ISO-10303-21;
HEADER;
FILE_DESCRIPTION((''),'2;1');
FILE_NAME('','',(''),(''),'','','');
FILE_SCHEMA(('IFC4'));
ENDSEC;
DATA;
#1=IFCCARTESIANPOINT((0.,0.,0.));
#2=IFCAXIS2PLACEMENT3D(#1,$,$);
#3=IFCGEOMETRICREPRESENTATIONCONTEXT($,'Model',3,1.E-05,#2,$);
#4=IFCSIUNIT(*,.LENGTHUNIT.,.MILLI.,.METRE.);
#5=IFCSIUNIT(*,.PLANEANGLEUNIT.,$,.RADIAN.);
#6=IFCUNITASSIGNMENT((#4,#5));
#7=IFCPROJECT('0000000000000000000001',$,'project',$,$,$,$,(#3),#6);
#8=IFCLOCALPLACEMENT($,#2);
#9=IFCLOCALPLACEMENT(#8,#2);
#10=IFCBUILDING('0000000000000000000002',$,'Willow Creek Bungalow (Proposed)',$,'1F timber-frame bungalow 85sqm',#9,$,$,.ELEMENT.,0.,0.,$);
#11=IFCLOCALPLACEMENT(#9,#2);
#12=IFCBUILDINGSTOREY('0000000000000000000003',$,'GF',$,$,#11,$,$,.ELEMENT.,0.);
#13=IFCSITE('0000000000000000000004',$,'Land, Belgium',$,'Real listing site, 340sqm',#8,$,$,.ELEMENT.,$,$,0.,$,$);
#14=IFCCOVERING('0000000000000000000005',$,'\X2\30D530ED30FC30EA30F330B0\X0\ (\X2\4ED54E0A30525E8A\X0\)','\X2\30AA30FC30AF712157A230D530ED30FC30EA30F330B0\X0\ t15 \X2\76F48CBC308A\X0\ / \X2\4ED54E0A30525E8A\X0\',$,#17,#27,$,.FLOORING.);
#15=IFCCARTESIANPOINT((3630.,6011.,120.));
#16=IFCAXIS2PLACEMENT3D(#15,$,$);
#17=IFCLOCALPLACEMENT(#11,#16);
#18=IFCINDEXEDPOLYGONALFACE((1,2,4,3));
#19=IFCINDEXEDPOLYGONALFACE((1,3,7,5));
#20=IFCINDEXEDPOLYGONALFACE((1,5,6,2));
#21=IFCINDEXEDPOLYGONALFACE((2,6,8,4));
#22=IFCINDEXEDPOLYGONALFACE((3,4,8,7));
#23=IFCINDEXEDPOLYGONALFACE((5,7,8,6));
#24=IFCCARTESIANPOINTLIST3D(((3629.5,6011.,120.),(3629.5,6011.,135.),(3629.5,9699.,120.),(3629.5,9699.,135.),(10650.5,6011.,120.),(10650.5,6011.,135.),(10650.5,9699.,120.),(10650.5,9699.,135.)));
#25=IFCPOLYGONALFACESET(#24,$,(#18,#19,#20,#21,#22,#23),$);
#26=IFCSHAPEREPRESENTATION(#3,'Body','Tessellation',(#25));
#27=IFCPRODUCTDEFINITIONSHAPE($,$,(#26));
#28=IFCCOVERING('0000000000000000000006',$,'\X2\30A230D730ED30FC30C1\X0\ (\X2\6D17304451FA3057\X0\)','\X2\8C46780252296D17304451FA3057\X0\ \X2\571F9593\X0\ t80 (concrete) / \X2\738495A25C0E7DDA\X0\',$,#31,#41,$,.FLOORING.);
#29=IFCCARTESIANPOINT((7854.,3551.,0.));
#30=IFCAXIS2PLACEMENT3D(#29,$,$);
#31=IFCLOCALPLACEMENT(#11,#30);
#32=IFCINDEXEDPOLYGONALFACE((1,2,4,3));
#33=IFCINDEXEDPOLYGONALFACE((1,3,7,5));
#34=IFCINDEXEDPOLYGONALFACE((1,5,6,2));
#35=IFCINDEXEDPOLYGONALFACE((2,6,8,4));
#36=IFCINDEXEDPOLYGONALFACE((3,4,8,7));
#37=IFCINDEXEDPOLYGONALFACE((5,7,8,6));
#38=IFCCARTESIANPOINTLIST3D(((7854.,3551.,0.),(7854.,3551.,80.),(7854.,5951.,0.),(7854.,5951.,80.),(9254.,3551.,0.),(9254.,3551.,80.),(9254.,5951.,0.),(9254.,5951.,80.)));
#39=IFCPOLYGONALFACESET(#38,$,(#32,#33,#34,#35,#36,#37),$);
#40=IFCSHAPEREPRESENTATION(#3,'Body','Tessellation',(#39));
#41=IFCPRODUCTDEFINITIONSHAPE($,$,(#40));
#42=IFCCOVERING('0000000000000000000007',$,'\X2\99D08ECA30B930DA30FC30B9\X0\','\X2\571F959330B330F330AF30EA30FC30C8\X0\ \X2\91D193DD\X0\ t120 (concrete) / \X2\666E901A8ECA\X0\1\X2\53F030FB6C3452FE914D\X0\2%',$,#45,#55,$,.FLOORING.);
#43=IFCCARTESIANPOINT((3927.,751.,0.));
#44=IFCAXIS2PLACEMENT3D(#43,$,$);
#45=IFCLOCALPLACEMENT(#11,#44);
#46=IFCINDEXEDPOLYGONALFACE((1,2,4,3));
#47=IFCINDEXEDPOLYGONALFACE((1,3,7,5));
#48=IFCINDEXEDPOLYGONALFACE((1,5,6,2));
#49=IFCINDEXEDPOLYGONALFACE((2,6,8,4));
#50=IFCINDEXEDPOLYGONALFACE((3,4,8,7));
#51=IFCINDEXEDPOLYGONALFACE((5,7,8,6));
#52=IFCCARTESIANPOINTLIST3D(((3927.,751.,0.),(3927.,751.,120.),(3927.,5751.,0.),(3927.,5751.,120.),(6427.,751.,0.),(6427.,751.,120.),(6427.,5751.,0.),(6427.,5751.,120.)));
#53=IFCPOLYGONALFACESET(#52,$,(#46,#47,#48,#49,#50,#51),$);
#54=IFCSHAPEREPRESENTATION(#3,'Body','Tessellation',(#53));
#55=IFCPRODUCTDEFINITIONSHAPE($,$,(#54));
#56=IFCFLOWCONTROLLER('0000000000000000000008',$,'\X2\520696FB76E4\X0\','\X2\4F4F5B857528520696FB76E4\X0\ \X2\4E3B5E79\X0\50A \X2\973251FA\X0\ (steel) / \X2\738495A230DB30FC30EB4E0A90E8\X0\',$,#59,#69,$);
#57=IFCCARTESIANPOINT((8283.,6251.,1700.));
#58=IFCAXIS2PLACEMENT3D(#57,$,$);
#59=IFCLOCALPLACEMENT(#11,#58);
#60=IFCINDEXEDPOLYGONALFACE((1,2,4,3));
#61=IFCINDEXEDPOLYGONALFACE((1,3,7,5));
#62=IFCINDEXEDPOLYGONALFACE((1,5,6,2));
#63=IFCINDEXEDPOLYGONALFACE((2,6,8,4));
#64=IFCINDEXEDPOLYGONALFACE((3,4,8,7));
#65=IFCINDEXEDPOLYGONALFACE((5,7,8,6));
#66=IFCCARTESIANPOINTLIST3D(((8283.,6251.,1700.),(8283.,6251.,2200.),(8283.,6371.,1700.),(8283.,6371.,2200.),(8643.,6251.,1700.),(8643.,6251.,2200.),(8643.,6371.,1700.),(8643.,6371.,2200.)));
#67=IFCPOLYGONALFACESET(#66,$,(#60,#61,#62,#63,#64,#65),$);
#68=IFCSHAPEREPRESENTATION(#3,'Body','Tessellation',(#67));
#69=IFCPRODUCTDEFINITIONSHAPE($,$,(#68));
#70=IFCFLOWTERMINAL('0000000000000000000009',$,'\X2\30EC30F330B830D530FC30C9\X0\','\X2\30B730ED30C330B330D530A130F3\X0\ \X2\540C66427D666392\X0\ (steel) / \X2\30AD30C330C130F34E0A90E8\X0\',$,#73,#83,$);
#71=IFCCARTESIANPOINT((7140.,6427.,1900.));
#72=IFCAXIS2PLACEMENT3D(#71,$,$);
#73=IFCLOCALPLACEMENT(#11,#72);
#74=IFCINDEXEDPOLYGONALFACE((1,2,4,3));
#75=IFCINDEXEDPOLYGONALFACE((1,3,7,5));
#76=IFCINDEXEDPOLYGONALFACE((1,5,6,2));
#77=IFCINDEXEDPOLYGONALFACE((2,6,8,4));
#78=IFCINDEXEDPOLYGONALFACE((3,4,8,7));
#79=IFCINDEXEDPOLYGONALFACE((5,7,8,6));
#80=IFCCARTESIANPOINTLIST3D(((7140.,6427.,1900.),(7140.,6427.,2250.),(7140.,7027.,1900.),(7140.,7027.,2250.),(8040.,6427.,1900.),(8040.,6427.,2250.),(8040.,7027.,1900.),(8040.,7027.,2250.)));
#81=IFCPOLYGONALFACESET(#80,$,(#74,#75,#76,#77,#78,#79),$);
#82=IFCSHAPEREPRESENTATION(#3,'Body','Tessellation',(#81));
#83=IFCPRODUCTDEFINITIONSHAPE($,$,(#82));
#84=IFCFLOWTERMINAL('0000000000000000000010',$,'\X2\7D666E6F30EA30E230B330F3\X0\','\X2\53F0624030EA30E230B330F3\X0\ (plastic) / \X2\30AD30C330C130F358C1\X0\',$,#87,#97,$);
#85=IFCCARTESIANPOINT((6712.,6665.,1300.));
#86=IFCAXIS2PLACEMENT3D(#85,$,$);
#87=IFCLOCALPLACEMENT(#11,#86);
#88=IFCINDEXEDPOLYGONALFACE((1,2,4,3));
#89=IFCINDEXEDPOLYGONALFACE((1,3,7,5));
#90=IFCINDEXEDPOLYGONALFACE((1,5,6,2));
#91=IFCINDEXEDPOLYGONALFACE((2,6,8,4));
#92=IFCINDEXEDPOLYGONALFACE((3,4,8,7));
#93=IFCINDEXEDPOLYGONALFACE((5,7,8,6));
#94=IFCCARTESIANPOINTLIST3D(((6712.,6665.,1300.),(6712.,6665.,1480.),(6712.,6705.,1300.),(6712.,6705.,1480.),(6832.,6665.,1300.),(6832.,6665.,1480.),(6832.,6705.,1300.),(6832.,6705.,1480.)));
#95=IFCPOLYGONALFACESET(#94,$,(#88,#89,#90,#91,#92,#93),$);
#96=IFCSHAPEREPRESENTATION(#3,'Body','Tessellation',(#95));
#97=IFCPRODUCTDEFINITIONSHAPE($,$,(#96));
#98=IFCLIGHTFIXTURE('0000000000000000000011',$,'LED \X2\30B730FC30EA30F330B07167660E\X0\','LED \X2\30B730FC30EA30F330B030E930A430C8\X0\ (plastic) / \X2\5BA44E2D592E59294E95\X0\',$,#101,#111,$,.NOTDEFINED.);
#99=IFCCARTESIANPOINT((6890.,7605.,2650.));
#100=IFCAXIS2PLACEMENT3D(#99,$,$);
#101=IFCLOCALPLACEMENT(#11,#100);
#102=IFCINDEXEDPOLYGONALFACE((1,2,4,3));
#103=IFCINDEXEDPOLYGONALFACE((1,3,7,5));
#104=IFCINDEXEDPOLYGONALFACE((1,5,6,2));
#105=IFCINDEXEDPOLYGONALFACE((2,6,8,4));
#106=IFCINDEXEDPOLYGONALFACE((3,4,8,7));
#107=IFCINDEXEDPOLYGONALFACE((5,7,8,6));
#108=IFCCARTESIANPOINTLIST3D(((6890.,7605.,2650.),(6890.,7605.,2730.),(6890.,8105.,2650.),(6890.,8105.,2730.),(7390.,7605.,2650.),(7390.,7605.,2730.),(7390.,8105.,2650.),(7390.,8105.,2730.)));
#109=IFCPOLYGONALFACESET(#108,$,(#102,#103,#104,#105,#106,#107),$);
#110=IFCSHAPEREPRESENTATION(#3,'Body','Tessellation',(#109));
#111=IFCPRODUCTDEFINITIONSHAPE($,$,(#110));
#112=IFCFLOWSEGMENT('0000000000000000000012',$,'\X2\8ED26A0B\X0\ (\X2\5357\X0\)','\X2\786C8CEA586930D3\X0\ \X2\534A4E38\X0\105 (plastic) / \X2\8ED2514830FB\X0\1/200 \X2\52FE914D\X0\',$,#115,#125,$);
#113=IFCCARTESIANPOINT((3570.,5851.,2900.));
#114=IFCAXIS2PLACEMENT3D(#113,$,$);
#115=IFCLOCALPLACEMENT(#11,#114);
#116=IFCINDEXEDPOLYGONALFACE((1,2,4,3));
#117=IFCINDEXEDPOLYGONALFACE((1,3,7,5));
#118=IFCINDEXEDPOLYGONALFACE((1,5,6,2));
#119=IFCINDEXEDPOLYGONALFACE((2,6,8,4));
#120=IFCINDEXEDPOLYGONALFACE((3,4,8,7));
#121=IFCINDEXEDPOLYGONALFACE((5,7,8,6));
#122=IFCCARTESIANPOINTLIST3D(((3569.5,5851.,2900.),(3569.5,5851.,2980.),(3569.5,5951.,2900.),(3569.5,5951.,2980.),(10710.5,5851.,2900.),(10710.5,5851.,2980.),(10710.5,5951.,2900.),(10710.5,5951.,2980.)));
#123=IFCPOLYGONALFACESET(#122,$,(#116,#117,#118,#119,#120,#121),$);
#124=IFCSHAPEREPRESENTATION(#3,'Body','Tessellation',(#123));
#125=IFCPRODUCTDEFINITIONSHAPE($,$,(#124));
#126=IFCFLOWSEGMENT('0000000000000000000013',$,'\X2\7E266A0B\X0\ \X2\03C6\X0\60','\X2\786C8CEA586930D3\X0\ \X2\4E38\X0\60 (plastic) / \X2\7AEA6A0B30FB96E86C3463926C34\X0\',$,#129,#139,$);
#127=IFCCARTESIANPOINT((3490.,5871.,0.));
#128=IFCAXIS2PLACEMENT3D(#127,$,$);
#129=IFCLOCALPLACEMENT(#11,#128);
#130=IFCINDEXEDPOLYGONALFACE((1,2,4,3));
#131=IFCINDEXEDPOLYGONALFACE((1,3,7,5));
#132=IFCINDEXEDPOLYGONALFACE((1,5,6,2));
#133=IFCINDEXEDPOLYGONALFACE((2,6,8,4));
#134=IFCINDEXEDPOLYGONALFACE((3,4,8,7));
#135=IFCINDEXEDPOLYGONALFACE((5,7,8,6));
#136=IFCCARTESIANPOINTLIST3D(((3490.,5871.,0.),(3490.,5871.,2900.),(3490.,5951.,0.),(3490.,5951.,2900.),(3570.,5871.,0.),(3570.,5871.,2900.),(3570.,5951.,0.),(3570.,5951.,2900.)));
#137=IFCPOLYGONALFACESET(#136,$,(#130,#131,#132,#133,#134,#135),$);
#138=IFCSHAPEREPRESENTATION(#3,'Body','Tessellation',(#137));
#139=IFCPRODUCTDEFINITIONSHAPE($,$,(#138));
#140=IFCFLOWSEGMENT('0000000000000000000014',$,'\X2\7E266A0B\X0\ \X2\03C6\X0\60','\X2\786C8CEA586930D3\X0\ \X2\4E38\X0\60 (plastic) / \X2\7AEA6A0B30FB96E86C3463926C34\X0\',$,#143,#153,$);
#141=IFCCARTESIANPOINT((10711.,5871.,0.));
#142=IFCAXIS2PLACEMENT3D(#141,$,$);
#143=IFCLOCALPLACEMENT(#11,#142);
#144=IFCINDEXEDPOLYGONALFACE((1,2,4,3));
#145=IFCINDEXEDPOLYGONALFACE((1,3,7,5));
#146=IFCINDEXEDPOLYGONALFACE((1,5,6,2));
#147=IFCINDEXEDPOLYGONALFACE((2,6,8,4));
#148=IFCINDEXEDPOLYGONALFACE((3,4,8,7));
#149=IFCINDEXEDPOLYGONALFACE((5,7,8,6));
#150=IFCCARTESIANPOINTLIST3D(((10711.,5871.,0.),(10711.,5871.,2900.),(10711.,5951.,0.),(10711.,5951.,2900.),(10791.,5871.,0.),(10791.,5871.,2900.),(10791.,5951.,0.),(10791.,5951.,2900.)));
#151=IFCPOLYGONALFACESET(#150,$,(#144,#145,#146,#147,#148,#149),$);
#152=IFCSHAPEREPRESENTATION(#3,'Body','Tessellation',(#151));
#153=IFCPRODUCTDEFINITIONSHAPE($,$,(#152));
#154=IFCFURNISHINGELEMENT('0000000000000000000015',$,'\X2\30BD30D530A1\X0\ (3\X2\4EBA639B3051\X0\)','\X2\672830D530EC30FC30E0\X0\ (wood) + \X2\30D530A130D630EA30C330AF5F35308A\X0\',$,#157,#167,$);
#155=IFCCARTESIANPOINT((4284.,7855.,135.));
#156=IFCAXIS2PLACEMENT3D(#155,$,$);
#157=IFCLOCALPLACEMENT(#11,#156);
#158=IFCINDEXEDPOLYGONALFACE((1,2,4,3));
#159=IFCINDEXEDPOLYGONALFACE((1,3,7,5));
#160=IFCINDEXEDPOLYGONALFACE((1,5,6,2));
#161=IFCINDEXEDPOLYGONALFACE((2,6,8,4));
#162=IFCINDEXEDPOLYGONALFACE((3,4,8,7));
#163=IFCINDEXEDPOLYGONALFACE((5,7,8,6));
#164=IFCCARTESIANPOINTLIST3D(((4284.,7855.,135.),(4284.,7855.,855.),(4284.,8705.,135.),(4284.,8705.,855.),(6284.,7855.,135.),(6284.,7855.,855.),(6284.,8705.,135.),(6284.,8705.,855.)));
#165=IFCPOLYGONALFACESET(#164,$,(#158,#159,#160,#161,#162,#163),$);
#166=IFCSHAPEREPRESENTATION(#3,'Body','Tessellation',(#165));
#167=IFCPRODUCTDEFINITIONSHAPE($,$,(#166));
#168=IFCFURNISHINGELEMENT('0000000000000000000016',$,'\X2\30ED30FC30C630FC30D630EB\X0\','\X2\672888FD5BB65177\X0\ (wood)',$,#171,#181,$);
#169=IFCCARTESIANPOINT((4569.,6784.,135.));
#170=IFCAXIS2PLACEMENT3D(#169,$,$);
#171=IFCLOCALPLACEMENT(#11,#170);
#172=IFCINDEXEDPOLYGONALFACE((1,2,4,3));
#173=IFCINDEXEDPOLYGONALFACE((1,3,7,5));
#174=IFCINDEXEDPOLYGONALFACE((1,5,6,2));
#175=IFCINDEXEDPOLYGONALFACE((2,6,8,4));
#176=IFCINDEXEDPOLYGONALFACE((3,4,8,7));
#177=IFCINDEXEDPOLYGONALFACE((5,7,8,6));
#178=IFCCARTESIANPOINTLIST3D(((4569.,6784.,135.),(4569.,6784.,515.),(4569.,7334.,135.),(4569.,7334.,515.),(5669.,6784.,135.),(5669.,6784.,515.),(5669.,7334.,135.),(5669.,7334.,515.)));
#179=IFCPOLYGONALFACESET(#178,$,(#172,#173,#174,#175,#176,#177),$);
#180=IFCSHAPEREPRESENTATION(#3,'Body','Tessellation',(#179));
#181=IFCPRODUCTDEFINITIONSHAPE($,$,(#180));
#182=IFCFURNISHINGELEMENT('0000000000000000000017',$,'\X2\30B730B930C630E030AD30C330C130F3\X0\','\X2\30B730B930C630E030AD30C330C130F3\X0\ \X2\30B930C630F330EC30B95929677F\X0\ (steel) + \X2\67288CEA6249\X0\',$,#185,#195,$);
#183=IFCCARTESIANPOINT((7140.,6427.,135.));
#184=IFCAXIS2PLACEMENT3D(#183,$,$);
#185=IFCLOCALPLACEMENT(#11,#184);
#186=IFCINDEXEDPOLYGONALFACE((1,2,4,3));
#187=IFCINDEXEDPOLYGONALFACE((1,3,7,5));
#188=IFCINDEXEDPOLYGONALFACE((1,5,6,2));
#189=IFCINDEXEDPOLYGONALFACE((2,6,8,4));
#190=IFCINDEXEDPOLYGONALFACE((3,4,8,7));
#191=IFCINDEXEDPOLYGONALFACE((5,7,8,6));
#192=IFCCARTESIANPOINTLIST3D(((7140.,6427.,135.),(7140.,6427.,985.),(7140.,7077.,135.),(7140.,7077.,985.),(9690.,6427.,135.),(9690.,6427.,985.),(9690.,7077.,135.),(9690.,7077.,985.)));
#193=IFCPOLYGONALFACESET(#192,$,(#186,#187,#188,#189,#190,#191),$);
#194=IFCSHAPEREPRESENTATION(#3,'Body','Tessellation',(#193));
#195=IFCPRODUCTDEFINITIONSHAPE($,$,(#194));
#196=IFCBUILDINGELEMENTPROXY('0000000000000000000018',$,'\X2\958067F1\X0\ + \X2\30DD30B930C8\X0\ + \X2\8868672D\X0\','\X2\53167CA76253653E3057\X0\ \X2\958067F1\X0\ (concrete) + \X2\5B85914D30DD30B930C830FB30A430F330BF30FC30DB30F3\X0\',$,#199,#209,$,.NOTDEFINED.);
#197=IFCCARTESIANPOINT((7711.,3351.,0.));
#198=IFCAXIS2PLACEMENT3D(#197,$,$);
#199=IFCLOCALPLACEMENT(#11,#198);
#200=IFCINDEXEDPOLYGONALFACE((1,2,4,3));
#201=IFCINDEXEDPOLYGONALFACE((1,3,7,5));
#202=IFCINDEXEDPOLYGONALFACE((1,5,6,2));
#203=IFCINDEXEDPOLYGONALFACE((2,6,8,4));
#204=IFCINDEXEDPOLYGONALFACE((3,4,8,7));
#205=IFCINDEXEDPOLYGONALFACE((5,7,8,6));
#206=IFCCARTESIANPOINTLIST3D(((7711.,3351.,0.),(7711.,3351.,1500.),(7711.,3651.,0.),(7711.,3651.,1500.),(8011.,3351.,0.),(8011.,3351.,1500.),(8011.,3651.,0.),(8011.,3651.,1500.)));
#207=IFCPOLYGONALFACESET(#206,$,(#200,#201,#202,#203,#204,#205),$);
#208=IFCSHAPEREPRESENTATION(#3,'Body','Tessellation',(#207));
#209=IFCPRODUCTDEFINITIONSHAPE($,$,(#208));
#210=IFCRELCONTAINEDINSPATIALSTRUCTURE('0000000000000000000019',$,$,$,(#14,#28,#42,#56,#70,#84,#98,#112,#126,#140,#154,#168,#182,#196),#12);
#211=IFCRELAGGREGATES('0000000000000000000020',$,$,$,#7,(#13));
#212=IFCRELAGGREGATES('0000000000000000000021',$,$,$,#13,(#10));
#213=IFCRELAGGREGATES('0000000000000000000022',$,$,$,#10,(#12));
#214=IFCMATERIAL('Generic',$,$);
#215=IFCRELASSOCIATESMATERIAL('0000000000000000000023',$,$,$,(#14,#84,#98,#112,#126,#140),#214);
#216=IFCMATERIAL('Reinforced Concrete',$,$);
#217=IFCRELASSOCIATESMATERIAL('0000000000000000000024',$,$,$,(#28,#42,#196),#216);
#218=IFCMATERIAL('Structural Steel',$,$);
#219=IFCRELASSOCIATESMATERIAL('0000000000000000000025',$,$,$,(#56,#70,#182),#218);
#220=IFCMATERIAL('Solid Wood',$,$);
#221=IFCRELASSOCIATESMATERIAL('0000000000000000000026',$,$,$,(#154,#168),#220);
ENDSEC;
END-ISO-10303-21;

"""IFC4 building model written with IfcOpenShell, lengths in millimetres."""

from ifc_helpers import new_model, si_unit, frame, frame_2d, origin, place, context, project, spatial, rectangle, extrude, material, element, save


model = new_model("IFC4")

# Units and contexts
model_context = context("Model", 3, precision=1e-05, world=origin())
ifc_project = project(units=[si_unit("LENGTHUNIT", "METRE", prefix="MILLI"), si_unit("PLANEANGLEUNIT", "RADIAN")], contexts=[model_context])

# Site, building, storey
site_placement = place(None, origin())
site = spatial("IfcSite", under=ifc_project, at=site_placement, Name="Land, Belgium", ObjectType="Real listing site, 340sqm", CompositionType="ELEMENT", RefElevation=0.0)
building_placement = place(site_placement, origin())
building = spatial("IfcBuilding", under=site, at=building_placement, Name="Willow Creek Bungalow (Proposed)", ObjectType="1F timber-frame bungalow 85sqm", CompositionType="ELEMENT", ElevationOfRefHeight=0.0, ElevationOfTerrain=0.0)
storey_placement = place(building_placement, origin())
storey = spatial("IfcBuildingStorey", under=building, at=storey_placement, Name="GF", CompositionType="ELEMENT", Elevation=0.0)

# Shared definitions
ifc_material_1 = material(Name="Solid Wood")

# Shared definitions
ifc_material_2 = material(Name="Reinforced Concrete")

# Shared definitions
ifc_material_3 = material(Name="Structural Steel")

# Coverings
ifc_material_4 = material(Name="Generic")
covering_1_placement = place(storey_placement, frame((3630.0, 6011.0, 120.0)))
element("IfcCovering", 1, at=covering_1_placement, inside=storey, material=ifc_material_4, Name="フローリング (仕上げ床)", Description="オーク無垢フローリング t15 直貼り / 仕上げ床", PredefinedType="FLOORING", context=model_context, shape_type="SweptSolid", body=[
    extrude(rectangle(XDim=7021.0, YDim=3688.0, at=frame_2d((3510.0, 1844.0))), frame((3630.0, 6011.0, 120.0)), (0.0, 0.0, 1.0), 15.0),
])
covering_2_placement = place(storey_placement, frame((7854.0, 3551.0, 0.0)))
element("IfcCovering", 2, at=covering_2_placement, inside=storey, material=ifc_material_2, Name="アプローチ (洗い出し)", Description="豆砂利洗い出し 土間 t80 (concrete) / 玄関導線", PredefinedType="FLOORING", context=model_context, shape_type="SweptSolid", body=[
    extrude(rectangle(XDim=1400.0, YDim=2400.0, at=frame_2d((700.0, 1200.0))), frame((7854.0, 3551.0, 0.0)), (0.0, 0.0, 1.0), 80.0),
])
covering_3_placement = place(storey_placement, frame((3927.0, 751.0, 0.0)))
element("IfcCovering", 3, at=covering_3_placement, inside=storey, material=ifc_material_2, Name="駐車スペース", Description="土間コンクリート 金鏝 t120 (concrete) / 普通車1台・水勾配2%", PredefinedType="FLOORING", context=model_context, shape_type="SweptSolid", body=[
    extrude(rectangle(XDim=2500.0, YDim=5000.0, at=frame_2d((1250.0, 2500.0))), frame((3927.0, 751.0, 0.0)), (0.0, 0.0, 1.0), 120.0),
])

# Flow controller
flow_controller_placement = place(storey_placement, frame((8283.0, 6251.0, 1700.0)))
element("IfcFlowController", 4, at=flow_controller_placement, inside=storey, material=ifc_material_3, Name="分電盤", Description="住宅用分電盤 主幹50A 露出 (steel) / 玄関ホール上部", context=model_context, shape_type="SweptSolid", body=[
    extrude(rectangle(XDim=360.0, YDim=120.0, at=frame_2d((180.0, 60.0))), frame((8283.0, 6251.0, 1700.0)), (0.0, 0.0, 1.0), 500.0),
])

# Flow terminals
flow_terminal_1_placement = place(storey_placement, frame((7140.0, 6427.0, 1900.0)))
element("IfcFlowTerminal", 5, at=flow_terminal_1_placement, inside=storey, material=ifc_material_3, Name="レンジフード", Description="シロッコファン 同時給排 (steel) / キッチン上部", context=model_context, shape_type="SweptSolid", body=[
    extrude(rectangle(XDim=900.0, YDim=600.0, at=frame_2d((450.0, 300.0))), frame((7140.0, 6427.0, 1900.0)), (0.0, 0.0, 1.0), 350.0),
])
flow_terminal_2_placement = place(storey_placement, frame((6712.0, 6665.0, 1300.0)))
element("IfcFlowTerminal", 6, at=flow_terminal_2_placement, inside=storey, material=ifc_material_4, Name="給湯リモコン", Description="台所リモコン (plastic) / キッチン壁", context=model_context, shape_type="SweptSolid", body=[
    extrude(rectangle(XDim=120.0, YDim=40.0, at=frame_2d((60.0, 20.0))), frame((6712.0, 6665.0, 1300.0)), (0.0, 0.0, 1.0), 180.0),
])

# Light fixture
light_fixture_placement = place(storey_placement, frame((6890.0, 7605.0, 2650.0)))
element("IfcLightFixture", 7, at=light_fixture_placement, inside=storey, material=ifc_material_4, Name="LED シーリング照明", Description="LED シーリングライト (plastic) / 室中央天井", PredefinedType="NOTDEFINED", context=model_context, shape_type="SweptSolid", body=[
    extrude(rectangle(XDim=500.0, YDim=500.0, at=frame_2d((250.0, 250.0))), frame((6890.0, 7605.0, 2650.0)), (0.0, 0.0, 1.0), 80.0),
])

# Flow segments
flow_segment_1_placement = place(storey_placement, frame((3570.0, 5851.0, 2900.0)))
element("IfcFlowSegment", 8, at=flow_segment_1_placement, inside=storey, material=ifc_material_4, Name="軒樋 (南)", Description="硬質塩ビ 半丸105 (plastic) / 軒先・1/200 勾配", context=model_context, shape_type="SweptSolid", body=[
    extrude(rectangle(XDim=7141.0, YDim=100.0, at=frame_2d((3570.0, 50.0))), frame((3570.0, 5851.0, 2900.0)), (0.0, 0.0, 1.0), 80.0),
])
flow_segment_2_placement = place(storey_placement, frame((3490.0, 5871.0, 0.0)))
element("IfcFlowSegment", 9, at=flow_segment_2_placement, inside=storey, material=ifc_material_4, Name="縦樋 φ60", Description="硬質塩ビ 丸60 (plastic) / 竪樋・雨水排水", context=model_context, shape_type="SweptSolid", body=[
    extrude(rectangle(XDim=80.0, YDim=80.0, at=frame_2d((40.0, 40.0))), frame((3490.0, 5871.0, 0.0)), (0.0, 0.0, 1.0), 2900.0),
])
flow_segment_3_placement = place(storey_placement, frame((10711.0, 5871.0, 0.0)))
element("IfcFlowSegment", 10, at=flow_segment_3_placement, inside=storey, material=ifc_material_4, Name="縦樋 φ60", Description="硬質塩ビ 丸60 (plastic) / 竪樋・雨水排水", context=model_context, shape_type="SweptSolid", body=[
    extrude(rectangle(XDim=80.0, YDim=80.0, at=frame_2d((40.0, 40.0))), frame((10711.0, 5871.0, 0.0)), (0.0, 0.0, 1.0), 2900.0),
])

# Furnishing elements
furnishing_1_placement = place(storey_placement, frame((4284.0, 7855.0, 135.0)))
element("IfcFurnishingElement", 11, at=furnishing_1_placement, inside=storey, material=ifc_material_1, Name="ソファ (3人掛け)", Description="木フレーム (wood) + ファブリック張り", context=model_context, shape_type="SweptSolid", body=[
    extrude(rectangle(XDim=2000.0, YDim=850.0, at=frame_2d((1000.0, 425.0))), frame((4284.0, 7855.0, 135.0)), (0.0, 0.0, 1.0), 720.0),
])
furnishing_2_placement = place(storey_placement, frame((4569.0, 6784.0, 135.0)))
element("IfcFurnishingElement", 12, at=furnishing_2_placement, inside=storey, material=ifc_material_1, Name="ローテーブル", Description="木製家具 (wood)", context=model_context, shape_type="SweptSolid", body=[
    extrude(rectangle(XDim=1100.0, YDim=550.0, at=frame_2d((550.0, 275.0))), frame((4569.0, 6784.0, 135.0)), (0.0, 0.0, 1.0), 380.0),
])
furnishing_3_placement = place(storey_placement, frame((7140.0, 6427.0, 135.0)))
element("IfcFurnishingElement", 13, at=furnishing_3_placement, inside=storey, material=ifc_material_3, Name="システムキッチン", Description="システムキッチン ステンレス天板 (steel) + 木質扉", context=model_context, shape_type="SweptSolid", body=[
    extrude(rectangle(XDim=2550.0, YDim=650.0, at=frame_2d((1275.0, 325.0))), frame((7140.0, 6427.0, 135.0)), (0.0, 0.0, 1.0), 850.0),
])

# Building element proxy
proxy_placement = place(storey_placement, frame((7711.0, 3351.0, 0.0)))
element("IfcBuildingElementProxy", 14, at=proxy_placement, inside=storey, material=ifc_material_2, Name="門柱 + ポスト + 表札", Description="化粧打放し 門柱 (concrete) + 宅配ポスト・インターホン", PredefinedType="NOTDEFINED", context=model_context, shape_type="SweptSolid", body=[
    extrude(rectangle(XDim=300.0, YDim=300.0, at=frame_2d((150.0, 150.0))), frame((7711.0, 3351.0, 0.0)), (0.0, 0.0, 1.0), 1500.0),
])

save(model, "model.ifc")
